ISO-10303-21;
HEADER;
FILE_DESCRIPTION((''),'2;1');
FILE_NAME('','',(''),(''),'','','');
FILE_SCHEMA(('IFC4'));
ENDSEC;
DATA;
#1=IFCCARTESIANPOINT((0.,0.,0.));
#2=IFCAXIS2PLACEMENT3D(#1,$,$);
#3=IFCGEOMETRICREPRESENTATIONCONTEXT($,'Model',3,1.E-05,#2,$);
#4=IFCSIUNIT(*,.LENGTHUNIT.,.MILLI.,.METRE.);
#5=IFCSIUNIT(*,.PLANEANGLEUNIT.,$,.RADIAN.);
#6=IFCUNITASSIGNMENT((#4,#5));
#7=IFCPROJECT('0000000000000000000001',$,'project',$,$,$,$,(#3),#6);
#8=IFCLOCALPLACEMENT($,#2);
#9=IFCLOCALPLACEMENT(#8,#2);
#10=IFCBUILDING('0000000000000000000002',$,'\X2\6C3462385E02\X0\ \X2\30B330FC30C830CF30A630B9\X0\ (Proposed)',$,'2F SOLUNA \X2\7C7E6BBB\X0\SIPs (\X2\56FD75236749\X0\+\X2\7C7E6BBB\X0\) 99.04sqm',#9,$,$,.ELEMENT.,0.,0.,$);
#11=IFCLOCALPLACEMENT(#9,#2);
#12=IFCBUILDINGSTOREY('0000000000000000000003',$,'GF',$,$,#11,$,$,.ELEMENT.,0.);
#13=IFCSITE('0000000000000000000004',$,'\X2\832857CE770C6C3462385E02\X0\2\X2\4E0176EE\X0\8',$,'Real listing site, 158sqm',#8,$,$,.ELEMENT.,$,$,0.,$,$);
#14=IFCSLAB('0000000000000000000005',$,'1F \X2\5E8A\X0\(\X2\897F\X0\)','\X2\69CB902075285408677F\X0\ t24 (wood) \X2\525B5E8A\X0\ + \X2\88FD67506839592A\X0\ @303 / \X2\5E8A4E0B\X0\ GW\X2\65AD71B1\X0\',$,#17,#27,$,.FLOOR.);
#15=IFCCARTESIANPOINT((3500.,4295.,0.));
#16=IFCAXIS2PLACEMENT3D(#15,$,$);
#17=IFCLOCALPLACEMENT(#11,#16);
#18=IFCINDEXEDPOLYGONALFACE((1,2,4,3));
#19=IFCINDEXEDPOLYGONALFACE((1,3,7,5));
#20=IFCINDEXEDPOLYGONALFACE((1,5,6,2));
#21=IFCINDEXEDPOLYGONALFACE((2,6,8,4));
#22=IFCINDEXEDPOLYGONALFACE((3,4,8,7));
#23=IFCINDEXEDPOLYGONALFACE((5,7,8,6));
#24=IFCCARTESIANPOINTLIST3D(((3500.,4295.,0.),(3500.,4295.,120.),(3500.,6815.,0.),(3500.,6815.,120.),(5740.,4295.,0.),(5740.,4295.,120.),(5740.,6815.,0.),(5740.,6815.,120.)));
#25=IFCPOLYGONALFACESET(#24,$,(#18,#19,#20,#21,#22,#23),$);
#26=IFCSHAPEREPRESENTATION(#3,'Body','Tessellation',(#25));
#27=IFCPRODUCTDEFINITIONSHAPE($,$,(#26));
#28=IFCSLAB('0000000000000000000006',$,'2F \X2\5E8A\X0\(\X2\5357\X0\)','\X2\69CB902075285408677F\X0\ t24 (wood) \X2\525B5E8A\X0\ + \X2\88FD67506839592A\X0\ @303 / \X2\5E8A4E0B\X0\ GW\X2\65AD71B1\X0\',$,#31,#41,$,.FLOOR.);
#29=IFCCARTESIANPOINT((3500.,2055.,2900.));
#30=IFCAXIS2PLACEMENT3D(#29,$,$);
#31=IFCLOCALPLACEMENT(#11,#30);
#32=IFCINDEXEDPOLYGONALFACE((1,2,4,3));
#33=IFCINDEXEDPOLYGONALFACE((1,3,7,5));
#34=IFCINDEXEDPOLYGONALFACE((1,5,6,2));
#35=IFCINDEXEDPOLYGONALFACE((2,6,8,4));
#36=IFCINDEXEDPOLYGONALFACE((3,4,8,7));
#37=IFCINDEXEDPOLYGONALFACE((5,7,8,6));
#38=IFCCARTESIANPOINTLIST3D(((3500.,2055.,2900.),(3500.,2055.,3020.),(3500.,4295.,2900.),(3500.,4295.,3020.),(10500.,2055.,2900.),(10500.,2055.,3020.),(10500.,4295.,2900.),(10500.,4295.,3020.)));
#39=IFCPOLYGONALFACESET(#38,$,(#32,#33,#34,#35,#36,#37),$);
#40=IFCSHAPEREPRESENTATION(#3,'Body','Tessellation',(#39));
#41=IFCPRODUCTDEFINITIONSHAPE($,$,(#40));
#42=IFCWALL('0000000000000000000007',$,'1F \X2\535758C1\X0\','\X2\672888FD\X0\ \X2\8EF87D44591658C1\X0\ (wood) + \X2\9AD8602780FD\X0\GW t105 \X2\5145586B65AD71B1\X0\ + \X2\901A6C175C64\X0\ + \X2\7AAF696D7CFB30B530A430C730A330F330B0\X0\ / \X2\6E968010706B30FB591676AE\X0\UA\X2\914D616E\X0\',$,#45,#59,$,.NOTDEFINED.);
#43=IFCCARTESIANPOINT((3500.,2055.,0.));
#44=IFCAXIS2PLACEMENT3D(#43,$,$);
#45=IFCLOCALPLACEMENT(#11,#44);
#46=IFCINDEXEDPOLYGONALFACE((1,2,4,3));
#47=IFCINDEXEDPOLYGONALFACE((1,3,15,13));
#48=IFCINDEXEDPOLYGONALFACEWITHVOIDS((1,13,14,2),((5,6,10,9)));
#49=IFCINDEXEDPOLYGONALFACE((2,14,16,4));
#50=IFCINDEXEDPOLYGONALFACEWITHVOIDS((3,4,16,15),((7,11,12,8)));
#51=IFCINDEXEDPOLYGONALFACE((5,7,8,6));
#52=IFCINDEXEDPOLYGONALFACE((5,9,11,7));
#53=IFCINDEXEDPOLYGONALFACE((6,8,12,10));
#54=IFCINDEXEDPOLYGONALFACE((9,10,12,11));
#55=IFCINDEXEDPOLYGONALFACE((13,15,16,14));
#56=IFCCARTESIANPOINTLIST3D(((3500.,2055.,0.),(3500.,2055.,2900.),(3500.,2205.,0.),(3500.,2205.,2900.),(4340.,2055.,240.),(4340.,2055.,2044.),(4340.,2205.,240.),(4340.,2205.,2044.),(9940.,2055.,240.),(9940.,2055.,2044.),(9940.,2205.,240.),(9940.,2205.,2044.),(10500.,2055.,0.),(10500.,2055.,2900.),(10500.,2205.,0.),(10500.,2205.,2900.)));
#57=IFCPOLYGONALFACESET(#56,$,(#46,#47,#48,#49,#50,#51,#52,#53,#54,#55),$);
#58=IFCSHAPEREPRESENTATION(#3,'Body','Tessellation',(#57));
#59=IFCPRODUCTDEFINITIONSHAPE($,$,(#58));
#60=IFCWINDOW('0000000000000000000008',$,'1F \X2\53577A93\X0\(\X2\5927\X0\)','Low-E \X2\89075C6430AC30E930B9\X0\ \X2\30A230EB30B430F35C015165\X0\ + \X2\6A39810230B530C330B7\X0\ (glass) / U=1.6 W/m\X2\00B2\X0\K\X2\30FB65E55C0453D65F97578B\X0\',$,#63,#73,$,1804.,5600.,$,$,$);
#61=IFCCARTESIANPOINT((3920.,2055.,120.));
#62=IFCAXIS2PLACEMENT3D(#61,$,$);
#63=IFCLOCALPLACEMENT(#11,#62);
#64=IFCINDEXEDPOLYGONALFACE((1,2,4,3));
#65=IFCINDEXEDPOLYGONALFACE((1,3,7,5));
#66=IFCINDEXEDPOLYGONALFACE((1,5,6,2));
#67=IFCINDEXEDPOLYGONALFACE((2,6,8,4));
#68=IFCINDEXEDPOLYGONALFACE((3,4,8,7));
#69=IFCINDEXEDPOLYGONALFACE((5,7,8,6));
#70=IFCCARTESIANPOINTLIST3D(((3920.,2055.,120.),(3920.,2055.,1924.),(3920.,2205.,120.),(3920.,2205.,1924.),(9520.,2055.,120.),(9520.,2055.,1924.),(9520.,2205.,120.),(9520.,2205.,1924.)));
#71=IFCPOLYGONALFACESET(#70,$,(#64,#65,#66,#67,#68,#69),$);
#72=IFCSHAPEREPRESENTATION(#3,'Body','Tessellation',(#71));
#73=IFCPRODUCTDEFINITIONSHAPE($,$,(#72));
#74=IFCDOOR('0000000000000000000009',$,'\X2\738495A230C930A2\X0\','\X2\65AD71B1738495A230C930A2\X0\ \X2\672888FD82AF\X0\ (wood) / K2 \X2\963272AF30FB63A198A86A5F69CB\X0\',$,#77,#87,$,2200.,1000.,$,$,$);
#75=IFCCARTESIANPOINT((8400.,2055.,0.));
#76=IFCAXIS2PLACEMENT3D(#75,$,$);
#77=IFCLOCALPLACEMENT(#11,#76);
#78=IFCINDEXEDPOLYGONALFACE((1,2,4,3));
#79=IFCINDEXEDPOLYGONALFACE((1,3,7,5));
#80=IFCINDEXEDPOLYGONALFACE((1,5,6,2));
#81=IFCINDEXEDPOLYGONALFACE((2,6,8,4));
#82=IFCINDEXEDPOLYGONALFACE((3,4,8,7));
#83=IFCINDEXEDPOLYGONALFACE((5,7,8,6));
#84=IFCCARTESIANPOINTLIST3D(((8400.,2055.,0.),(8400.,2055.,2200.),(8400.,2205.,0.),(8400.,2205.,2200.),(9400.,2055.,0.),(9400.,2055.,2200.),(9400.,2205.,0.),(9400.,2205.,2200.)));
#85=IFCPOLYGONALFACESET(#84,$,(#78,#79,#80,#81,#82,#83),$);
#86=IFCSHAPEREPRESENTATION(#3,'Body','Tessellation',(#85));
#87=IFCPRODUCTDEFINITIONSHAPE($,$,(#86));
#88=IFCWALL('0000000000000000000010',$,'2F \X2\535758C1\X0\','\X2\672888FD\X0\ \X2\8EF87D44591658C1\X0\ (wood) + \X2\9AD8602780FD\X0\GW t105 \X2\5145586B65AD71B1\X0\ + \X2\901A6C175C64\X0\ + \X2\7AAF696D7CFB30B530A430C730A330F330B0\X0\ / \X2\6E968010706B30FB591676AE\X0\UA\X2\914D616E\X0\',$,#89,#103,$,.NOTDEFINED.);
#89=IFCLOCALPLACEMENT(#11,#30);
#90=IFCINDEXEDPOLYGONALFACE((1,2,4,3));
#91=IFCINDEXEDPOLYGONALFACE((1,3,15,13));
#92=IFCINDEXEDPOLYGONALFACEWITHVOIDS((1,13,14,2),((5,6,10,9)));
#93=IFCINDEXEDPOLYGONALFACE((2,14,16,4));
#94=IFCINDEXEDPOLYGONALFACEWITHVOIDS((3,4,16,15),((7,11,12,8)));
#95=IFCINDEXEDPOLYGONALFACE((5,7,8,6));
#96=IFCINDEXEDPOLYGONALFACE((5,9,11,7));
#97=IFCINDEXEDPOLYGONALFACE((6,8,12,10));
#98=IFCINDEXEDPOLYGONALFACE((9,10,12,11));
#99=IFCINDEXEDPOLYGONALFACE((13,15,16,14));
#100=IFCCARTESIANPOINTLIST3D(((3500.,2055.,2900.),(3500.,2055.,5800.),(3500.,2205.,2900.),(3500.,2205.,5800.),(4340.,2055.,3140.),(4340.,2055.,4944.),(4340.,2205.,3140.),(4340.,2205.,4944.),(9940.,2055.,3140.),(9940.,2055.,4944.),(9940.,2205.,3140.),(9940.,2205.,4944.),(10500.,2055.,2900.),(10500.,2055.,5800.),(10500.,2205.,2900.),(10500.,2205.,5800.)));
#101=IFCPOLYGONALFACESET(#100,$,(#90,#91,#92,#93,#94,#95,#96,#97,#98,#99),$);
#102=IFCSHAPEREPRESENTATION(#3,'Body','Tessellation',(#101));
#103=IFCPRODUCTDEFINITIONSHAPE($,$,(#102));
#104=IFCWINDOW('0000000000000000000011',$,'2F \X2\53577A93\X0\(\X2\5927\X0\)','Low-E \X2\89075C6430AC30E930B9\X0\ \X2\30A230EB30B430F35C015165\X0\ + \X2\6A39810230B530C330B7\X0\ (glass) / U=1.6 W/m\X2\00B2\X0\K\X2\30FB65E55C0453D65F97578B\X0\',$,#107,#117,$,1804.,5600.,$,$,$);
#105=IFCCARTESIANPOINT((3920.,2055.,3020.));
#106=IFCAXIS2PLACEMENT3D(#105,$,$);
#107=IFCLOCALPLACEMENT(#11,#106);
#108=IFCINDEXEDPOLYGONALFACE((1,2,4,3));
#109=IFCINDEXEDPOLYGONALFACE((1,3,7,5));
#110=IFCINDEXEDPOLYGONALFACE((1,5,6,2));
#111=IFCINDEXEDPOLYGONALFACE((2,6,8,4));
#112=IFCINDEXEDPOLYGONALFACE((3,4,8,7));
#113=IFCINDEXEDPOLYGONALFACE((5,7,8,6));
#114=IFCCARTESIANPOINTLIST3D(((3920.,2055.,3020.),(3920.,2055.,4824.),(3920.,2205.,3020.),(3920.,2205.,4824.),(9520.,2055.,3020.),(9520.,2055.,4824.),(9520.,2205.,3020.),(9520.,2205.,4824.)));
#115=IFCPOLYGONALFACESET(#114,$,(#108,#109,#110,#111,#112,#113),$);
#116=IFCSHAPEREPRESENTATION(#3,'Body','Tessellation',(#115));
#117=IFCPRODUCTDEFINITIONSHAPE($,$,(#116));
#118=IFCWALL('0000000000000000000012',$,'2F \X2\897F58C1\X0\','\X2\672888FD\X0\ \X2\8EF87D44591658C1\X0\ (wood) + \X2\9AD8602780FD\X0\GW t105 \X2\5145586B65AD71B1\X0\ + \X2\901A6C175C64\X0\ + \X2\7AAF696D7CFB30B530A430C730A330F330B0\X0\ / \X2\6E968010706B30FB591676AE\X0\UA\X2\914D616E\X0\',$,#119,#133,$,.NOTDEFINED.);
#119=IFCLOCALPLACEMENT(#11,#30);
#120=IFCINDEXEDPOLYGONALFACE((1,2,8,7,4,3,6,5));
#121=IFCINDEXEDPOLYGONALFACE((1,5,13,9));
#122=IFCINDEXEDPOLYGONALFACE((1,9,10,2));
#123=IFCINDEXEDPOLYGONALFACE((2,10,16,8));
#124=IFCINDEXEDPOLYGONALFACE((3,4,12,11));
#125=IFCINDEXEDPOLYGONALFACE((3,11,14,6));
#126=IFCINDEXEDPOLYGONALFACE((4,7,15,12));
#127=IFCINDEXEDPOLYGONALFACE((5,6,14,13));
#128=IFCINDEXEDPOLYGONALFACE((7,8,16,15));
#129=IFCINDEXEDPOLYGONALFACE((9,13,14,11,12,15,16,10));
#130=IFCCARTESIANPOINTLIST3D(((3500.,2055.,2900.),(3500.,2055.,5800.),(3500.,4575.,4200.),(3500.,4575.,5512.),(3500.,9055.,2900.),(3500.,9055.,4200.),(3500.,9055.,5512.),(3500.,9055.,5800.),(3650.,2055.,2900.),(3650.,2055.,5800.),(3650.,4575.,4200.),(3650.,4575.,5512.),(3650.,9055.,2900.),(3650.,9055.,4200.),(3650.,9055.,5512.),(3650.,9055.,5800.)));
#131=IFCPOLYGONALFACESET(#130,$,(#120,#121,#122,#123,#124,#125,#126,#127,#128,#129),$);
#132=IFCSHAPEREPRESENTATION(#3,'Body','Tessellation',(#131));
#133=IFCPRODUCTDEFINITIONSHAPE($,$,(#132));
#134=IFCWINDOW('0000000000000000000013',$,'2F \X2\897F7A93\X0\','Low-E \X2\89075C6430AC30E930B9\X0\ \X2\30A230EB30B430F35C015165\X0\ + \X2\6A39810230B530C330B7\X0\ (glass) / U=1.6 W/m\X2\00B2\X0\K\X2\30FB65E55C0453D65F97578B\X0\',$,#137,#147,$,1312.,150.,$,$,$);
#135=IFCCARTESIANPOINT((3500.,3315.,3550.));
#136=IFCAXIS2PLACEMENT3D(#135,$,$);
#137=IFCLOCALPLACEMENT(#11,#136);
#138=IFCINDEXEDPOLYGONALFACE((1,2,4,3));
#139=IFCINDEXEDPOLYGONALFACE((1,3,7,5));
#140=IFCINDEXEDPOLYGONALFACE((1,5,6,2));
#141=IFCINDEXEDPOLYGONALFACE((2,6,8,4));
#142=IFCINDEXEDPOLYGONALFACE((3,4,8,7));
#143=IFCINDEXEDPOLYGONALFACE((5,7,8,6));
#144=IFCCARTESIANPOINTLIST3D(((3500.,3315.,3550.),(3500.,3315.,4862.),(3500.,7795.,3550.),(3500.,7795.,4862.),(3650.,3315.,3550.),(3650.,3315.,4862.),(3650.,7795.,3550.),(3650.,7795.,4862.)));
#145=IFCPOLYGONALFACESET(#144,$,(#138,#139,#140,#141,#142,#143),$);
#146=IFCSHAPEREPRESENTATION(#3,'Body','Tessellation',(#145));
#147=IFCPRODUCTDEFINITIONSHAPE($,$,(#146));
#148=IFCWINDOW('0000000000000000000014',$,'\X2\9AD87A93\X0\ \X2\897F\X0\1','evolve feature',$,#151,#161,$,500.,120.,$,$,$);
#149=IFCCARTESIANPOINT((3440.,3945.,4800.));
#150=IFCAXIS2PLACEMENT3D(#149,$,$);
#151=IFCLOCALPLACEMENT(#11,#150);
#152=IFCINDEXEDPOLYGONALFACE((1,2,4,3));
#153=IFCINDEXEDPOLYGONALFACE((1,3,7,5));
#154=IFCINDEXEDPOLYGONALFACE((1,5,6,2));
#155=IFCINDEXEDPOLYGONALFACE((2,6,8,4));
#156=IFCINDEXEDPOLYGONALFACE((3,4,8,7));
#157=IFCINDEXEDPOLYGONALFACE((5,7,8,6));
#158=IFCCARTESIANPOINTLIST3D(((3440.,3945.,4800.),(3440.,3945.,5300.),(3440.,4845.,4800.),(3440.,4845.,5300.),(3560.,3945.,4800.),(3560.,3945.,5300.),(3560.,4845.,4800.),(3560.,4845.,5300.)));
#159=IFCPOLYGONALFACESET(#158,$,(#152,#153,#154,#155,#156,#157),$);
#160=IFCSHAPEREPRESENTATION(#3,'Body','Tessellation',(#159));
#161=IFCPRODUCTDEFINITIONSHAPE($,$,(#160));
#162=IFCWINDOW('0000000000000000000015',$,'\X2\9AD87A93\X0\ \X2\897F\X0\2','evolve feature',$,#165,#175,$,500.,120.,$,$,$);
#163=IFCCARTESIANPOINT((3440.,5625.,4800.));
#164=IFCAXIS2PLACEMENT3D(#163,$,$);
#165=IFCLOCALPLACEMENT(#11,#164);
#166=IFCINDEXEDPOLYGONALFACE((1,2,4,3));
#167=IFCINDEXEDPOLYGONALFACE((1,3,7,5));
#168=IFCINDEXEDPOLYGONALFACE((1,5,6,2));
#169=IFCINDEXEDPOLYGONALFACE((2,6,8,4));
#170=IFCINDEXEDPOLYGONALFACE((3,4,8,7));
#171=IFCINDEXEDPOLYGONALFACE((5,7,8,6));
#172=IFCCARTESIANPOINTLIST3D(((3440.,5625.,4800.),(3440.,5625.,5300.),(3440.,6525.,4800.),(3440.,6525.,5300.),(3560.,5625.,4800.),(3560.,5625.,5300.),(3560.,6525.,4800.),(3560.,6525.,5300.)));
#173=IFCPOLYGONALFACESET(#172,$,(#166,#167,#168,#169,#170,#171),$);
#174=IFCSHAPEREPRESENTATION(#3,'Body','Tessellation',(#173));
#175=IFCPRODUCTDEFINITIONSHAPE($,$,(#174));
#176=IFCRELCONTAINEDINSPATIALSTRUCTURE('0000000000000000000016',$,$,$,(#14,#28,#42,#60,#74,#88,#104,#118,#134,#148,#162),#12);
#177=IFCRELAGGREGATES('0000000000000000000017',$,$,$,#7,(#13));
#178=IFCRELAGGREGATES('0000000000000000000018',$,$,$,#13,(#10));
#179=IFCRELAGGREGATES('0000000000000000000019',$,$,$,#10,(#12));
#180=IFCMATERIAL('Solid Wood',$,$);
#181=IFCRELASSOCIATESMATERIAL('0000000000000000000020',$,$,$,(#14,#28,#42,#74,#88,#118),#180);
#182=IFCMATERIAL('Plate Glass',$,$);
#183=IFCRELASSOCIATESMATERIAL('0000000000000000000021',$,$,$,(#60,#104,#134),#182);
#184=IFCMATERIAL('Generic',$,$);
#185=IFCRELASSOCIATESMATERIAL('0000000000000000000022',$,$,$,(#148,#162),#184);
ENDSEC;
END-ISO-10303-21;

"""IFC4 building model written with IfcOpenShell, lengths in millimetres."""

from ifc_helpers import new_model, si_unit, frame, frame_2d, origin, place, context, project, spatial, rectangle, extrude, material, element, fill, save


model = new_model("IFC4")

# Units and contexts
model_context = context("Model", 3, precision=1e-05, world=origin())
ifc_project = project(units=[si_unit("LENGTHUNIT", "METRE", prefix="MILLI"), si_unit("PLANEANGLEUNIT", "RADIAN")], contexts=[model_context])

# Site, building, storey
site_placement = place(None, origin())
site = spatial("IfcSite", under=ifc_project, at=site_placement, Name="茨城県水戸市2丁目8", ObjectType="Real listing site, 158sqm", CompositionType="ELEMENT", RefElevation=0.0)
building_placement = place(site_placement, origin())
building = spatial("IfcBuilding", under=site, at=building_placement, Name="水戸市 コートハウス (Proposed)", ObjectType="2F SOLUNA 籾殻SIPs (国産杉+籾殻) 99.04sqm", CompositionType="ELEMENT", ElevationOfRefHeight=0.0, ElevationOfTerrain=0.0)
storey_placement = place(building_placement, origin())
storey = spatial("IfcBuildingStorey", under=building, at=storey_placement, Name="GF", CompositionType="ELEMENT", Elevation=0.0)

# Slabs
ifc_material_1 = material(Name="Solid Wood")
slab_1_placement = place(storey_placement, frame((3500.0, 4295.0, 0.0)))
element("IfcSlab", 1, at=slab_1_placement, inside=storey, material=ifc_material_1, Name="1F 床(西)", Description="構造用合板 t24 (wood) 剛床 + 製材根太 @303 / 床下 GW断熱", PredefinedType="FLOOR", context=model_context, shape_type="SweptSolid", body=[
    extrude(rectangle(XDim=2240.0, YDim=2520.0, at=frame_2d((1120.0, 1260.0))), frame((3500.0, 4295.0, 0.0)), (0.0, 0.0, 1.0), 120.0),
])
slab_2_placement = place(storey_placement, frame((3500.0, 2055.0, 2900.0)))
element("IfcSlab", 2, at=slab_2_placement, inside=storey, material=ifc_material_1, Name="2F 床(南)", Description="構造用合板 t24 (wood) 剛床 + 製材根太 @303 / 床下 GW断熱", PredefinedType="FLOOR", context=model_context, shape_type="SweptSolid", body=[
    extrude(rectangle(XDim=7000.0, YDim=2240.0, at=frame_2d((3500.0, 1120.0))), frame((3500.0, 2055.0, 2900.0)), (0.0, 0.0, 1.0), 120.0),
])
ifc_material_2 = material(Name="Generic")

# Wall, openings, window, door
wall_1_placement = place(storey_placement, frame((3500.0, 2055.0, 0.0)))
wall_1 = element("IfcWall", 3, at=wall_1_placement, inside=storey, material=ifc_material_1, Name="1F 南壁", Description="木製 軸組外壁 (wood) + 高性能GW t105 充填断熱 + 通気層 + 窯業系サイディング / 準耐火・外皮UA配慮", PredefinedType="NOTDEFINED", context=model_context, shape_type="SweptSolid", body=[
    extrude(rectangle(XDim=7000.0, YDim=150.0, at=frame_2d((3500.0, 75.0))), frame((3500.0, 2055.0, 0.0)), (0.0, 0.0, 1.0), 2900.0),
])
opening_1_placement = place(storey_placement, frame((3920.0, 2055.0, 120.0)))
opening_1 = element("IfcOpeningElement", 4, at=opening_1_placement, cuts=wall_1, PredefinedType="NOTDEFINED", context=model_context, shape_type="SweptSolid", body=[
    extrude(rectangle(XDim=5600.0, YDim=150.0, at=frame_2d((2800.0, 75.0))), frame((3920.0, 2055.0, 120.0)), (0.0, 0.0, 1.0), 1804.0),
])
opening_2_placement = place(storey_placement, frame((8400.0, 2055.0, 0.0)))
opening_2 = element("IfcOpeningElement", 5, at=opening_2_placement, cuts=wall_1, PredefinedType="NOTDEFINED", context=model_context, shape_type="SweptSolid", body=[
    extrude(rectangle(XDim=1000.0, YDim=150.0, at=frame_2d((500.0, 75.0))), frame((8400.0, 2055.0, 0.0)), (0.0, 0.0, 1.0), 2200.0),
])
ifc_material_3 = material(Name="Plate Glass")
window_1_placement = place(storey_placement, frame((3920.0, 2055.0, 120.0)))
window_1 = element("IfcWindow", 6, at=window_1_placement, inside=storey, material=ifc_material_3, Name="1F 南窓(大)", Description="Low-E 複層ガラス アルゴン封入 + 樹脂サッシ (glass) / U=1.6 W/m²K・日射取得型", OverallHeight=1804.0, OverallWidth=5600.0, context=model_context, shape_type="SweptSolid", body=[
    extrude(rectangle(XDim=5600.0, YDim=150.0, at=frame_2d((2800.0, 75.0))), frame((3920.0, 2055.0, 120.0)), (0.0, 0.0, 1.0), 1804.0),
])
fill(opening_1, window_1)
door_placement = place(storey_placement, frame((8400.0, 2055.0, 0.0)))
door = element("IfcDoor", 7, at=door_placement, inside=storey, material=ifc_material_1, Name="玄関ドア", Description="断熱玄関ドア 木製芯 (wood) / K2 防犯・採風機構", OverallHeight=2200.0, OverallWidth=1000.0, context=model_context, shape_type="SweptSolid", body=[
    extrude(rectangle(XDim=1000.0, YDim=150.0, at=frame_2d((500.0, 75.0))), frame((8400.0, 2055.0, 0.0)), (0.0, 0.0, 1.0), 2200.0),
])
fill(opening_2, door)

# Wall, opening, window
wall_2_placement = place(storey_placement, frame((3500.0, 2055.0, 2900.0)))
wall_2 = element("IfcWall", 8, at=wall_2_placement, inside=storey, material=ifc_material_1, Name="2F 南壁", Description="木製 軸組外壁 (wood) + 高性能GW t105 充填断熱 + 通気層 + 窯業系サイディング / 準耐火・外皮UA配慮", PredefinedType="NOTDEFINED", context=model_context, shape_type="SweptSolid", body=[
    extrude(rectangle(XDim=7000.0, YDim=150.0, at=frame_2d((3500.0, 75.0))), frame((3500.0, 2055.0, 2900.0)), (0.0, 0.0, 1.0), 2900.0),
])
opening_3_placement = place(storey_placement, frame((3920.0, 2055.0, 3020.0)))
opening_3 = element("IfcOpeningElement", 9, at=opening_3_placement, cuts=wall_2, PredefinedType="NOTDEFINED", context=model_context, shape_type="SweptSolid", body=[
    extrude(rectangle(XDim=5600.0, YDim=150.0, at=frame_2d((2800.0, 75.0))), frame((3920.0, 2055.0, 3020.0)), (0.0, 0.0, 1.0), 1804.0),
])
window_2_placement = place(storey_placement, frame((3920.0, 2055.0, 3020.0)))
window_2 = element("IfcWindow", 10, at=window_2_placement, inside=storey, material=ifc_material_3, Name="2F 南窓(大)", Description="Low-E 複層ガラス アルゴン封入 + 樹脂サッシ (glass) / U=1.6 W/m²K・日射取得型", OverallHeight=1804.0, OverallWidth=5600.0, context=model_context, shape_type="SweptSolid", body=[
    extrude(rectangle(XDim=5600.0, YDim=150.0, at=frame_2d((2800.0, 75.0))), frame((3920.0, 2055.0, 3020.0)), (0.0, 0.0, 1.0), 1804.0),
])
fill(opening_3, window_2)

# Wall, openings, windows
wall_3_placement = place(storey_placement, frame((3500.0, 2055.0, 2900.0)))
wall_3 = element("IfcWall", 11, at=wall_3_placement, inside=storey, material=ifc_material_1, Name="2F 西壁", Description="木製 軸組外壁 (wood) + 高性能GW t105 充填断熱 + 通気層 + 窯業系サイディング / 準耐火・外皮UA配慮", PredefinedType="NOTDEFINED", context=model_context, shape_type="SweptSolid", body=[
    extrude(rectangle(XDim=150.0, YDim=7000.0, at=frame_2d((75.0, 3500.0))), frame((3500.0, 2055.0, 2900.0)), (0.0, 0.0, 1.0), 2900.0),
])
opening_4_placement = place(storey_placement, frame((3500.0, 3315.0, 3550.0)))
opening_4 = element("IfcOpeningElement", 12, at=opening_4_placement, cuts=wall_3, PredefinedType="NOTDEFINED", context=model_context, shape_type="SweptSolid", body=[
    extrude(rectangle(XDim=150.0, YDim=4480.0, at=frame_2d((75.0, 2240.0))), frame((3500.0, 3315.0, 3550.0)), (0.0, 0.0, 1.0), 1312.0),
])
opening_5_placement = place(storey_placement, frame((3440.0, 3945.0, 4800.0)))
opening_5 = element("IfcOpeningElement", 13, at=opening_5_placement, cuts=wall_3, PredefinedType="NOTDEFINED", context=model_context, shape_type="SweptSolid", body=[
    extrude(rectangle(XDim=120.0, YDim=900.0, at=frame_2d((60.0, 450.0))), frame((3440.0, 3945.0, 4800.0)), (0.0, 0.0, 1.0), 500.0),
])
opening_6_placement = place(storey_placement, frame((3440.0, 5625.0, 4800.0)))
opening_6 = element("IfcOpeningElement", 14, at=opening_6_placement, cuts=wall_3, PredefinedType="NOTDEFINED", context=model_context, shape_type="SweptSolid", body=[
    extrude(rectangle(XDim=120.0, YDim=900.0, at=frame_2d((60.0, 450.0))), frame((3440.0, 5625.0, 4800.0)), (0.0, 0.0, 1.0), 500.0),
])
window_3_placement = place(storey_placement, frame((3500.0, 3315.0, 3550.0)))
window_3 = element("IfcWindow", 15, at=window_3_placement, inside=storey, material=ifc_material_3, Name="2F 西窓", Description="Low-E 複層ガラス アルゴン封入 + 樹脂サッシ (glass) / U=1.6 W/m²K・日射取得型", OverallHeight=1312.0, OverallWidth=150.0, context=model_context, shape_type="SweptSolid", body=[
    extrude(rectangle(XDim=150.0, YDim=4480.0, at=frame_2d((75.0, 2240.0))), frame((3500.0, 3315.0, 3550.0)), (0.0, 0.0, 1.0), 1312.0),
])
fill(opening_4, window_3)
window_4_placement = place(storey_placement, frame((3440.0, 3945.0, 4800.0)))
window_4 = element("IfcWindow", 16, at=window_4_placement, inside=storey, material=ifc_material_2, Name="高窓 西1", Description="evolve feature", OverallHeight=500.0, OverallWidth=120.0, context=model_context, shape_type="SweptSolid", body=[
    extrude(rectangle(XDim=120.0, YDim=900.0, at=frame_2d((60.0, 450.0))), frame((3440.0, 3945.0, 4800.0)), (0.0, 0.0, 1.0), 500.0),
])
fill(opening_5, window_4)
window_5_placement = place(storey_placement, frame((3440.0, 5625.0, 4800.0)))
window_5 = element("IfcWindow", 17, at=window_5_placement, inside=storey, material=ifc_material_2, Name="高窓 西2", Description="evolve feature", OverallHeight=500.0, OverallWidth=120.0, context=model_context, shape_type="SweptSolid", body=[
    extrude(rectangle(XDim=120.0, YDim=900.0, at=frame_2d((60.0, 450.0))), frame((3440.0, 5625.0, 4800.0)), (0.0, 0.0, 1.0), 500.0),
])
fill(opening_6, window_5)

save(model, "model.ifc")
